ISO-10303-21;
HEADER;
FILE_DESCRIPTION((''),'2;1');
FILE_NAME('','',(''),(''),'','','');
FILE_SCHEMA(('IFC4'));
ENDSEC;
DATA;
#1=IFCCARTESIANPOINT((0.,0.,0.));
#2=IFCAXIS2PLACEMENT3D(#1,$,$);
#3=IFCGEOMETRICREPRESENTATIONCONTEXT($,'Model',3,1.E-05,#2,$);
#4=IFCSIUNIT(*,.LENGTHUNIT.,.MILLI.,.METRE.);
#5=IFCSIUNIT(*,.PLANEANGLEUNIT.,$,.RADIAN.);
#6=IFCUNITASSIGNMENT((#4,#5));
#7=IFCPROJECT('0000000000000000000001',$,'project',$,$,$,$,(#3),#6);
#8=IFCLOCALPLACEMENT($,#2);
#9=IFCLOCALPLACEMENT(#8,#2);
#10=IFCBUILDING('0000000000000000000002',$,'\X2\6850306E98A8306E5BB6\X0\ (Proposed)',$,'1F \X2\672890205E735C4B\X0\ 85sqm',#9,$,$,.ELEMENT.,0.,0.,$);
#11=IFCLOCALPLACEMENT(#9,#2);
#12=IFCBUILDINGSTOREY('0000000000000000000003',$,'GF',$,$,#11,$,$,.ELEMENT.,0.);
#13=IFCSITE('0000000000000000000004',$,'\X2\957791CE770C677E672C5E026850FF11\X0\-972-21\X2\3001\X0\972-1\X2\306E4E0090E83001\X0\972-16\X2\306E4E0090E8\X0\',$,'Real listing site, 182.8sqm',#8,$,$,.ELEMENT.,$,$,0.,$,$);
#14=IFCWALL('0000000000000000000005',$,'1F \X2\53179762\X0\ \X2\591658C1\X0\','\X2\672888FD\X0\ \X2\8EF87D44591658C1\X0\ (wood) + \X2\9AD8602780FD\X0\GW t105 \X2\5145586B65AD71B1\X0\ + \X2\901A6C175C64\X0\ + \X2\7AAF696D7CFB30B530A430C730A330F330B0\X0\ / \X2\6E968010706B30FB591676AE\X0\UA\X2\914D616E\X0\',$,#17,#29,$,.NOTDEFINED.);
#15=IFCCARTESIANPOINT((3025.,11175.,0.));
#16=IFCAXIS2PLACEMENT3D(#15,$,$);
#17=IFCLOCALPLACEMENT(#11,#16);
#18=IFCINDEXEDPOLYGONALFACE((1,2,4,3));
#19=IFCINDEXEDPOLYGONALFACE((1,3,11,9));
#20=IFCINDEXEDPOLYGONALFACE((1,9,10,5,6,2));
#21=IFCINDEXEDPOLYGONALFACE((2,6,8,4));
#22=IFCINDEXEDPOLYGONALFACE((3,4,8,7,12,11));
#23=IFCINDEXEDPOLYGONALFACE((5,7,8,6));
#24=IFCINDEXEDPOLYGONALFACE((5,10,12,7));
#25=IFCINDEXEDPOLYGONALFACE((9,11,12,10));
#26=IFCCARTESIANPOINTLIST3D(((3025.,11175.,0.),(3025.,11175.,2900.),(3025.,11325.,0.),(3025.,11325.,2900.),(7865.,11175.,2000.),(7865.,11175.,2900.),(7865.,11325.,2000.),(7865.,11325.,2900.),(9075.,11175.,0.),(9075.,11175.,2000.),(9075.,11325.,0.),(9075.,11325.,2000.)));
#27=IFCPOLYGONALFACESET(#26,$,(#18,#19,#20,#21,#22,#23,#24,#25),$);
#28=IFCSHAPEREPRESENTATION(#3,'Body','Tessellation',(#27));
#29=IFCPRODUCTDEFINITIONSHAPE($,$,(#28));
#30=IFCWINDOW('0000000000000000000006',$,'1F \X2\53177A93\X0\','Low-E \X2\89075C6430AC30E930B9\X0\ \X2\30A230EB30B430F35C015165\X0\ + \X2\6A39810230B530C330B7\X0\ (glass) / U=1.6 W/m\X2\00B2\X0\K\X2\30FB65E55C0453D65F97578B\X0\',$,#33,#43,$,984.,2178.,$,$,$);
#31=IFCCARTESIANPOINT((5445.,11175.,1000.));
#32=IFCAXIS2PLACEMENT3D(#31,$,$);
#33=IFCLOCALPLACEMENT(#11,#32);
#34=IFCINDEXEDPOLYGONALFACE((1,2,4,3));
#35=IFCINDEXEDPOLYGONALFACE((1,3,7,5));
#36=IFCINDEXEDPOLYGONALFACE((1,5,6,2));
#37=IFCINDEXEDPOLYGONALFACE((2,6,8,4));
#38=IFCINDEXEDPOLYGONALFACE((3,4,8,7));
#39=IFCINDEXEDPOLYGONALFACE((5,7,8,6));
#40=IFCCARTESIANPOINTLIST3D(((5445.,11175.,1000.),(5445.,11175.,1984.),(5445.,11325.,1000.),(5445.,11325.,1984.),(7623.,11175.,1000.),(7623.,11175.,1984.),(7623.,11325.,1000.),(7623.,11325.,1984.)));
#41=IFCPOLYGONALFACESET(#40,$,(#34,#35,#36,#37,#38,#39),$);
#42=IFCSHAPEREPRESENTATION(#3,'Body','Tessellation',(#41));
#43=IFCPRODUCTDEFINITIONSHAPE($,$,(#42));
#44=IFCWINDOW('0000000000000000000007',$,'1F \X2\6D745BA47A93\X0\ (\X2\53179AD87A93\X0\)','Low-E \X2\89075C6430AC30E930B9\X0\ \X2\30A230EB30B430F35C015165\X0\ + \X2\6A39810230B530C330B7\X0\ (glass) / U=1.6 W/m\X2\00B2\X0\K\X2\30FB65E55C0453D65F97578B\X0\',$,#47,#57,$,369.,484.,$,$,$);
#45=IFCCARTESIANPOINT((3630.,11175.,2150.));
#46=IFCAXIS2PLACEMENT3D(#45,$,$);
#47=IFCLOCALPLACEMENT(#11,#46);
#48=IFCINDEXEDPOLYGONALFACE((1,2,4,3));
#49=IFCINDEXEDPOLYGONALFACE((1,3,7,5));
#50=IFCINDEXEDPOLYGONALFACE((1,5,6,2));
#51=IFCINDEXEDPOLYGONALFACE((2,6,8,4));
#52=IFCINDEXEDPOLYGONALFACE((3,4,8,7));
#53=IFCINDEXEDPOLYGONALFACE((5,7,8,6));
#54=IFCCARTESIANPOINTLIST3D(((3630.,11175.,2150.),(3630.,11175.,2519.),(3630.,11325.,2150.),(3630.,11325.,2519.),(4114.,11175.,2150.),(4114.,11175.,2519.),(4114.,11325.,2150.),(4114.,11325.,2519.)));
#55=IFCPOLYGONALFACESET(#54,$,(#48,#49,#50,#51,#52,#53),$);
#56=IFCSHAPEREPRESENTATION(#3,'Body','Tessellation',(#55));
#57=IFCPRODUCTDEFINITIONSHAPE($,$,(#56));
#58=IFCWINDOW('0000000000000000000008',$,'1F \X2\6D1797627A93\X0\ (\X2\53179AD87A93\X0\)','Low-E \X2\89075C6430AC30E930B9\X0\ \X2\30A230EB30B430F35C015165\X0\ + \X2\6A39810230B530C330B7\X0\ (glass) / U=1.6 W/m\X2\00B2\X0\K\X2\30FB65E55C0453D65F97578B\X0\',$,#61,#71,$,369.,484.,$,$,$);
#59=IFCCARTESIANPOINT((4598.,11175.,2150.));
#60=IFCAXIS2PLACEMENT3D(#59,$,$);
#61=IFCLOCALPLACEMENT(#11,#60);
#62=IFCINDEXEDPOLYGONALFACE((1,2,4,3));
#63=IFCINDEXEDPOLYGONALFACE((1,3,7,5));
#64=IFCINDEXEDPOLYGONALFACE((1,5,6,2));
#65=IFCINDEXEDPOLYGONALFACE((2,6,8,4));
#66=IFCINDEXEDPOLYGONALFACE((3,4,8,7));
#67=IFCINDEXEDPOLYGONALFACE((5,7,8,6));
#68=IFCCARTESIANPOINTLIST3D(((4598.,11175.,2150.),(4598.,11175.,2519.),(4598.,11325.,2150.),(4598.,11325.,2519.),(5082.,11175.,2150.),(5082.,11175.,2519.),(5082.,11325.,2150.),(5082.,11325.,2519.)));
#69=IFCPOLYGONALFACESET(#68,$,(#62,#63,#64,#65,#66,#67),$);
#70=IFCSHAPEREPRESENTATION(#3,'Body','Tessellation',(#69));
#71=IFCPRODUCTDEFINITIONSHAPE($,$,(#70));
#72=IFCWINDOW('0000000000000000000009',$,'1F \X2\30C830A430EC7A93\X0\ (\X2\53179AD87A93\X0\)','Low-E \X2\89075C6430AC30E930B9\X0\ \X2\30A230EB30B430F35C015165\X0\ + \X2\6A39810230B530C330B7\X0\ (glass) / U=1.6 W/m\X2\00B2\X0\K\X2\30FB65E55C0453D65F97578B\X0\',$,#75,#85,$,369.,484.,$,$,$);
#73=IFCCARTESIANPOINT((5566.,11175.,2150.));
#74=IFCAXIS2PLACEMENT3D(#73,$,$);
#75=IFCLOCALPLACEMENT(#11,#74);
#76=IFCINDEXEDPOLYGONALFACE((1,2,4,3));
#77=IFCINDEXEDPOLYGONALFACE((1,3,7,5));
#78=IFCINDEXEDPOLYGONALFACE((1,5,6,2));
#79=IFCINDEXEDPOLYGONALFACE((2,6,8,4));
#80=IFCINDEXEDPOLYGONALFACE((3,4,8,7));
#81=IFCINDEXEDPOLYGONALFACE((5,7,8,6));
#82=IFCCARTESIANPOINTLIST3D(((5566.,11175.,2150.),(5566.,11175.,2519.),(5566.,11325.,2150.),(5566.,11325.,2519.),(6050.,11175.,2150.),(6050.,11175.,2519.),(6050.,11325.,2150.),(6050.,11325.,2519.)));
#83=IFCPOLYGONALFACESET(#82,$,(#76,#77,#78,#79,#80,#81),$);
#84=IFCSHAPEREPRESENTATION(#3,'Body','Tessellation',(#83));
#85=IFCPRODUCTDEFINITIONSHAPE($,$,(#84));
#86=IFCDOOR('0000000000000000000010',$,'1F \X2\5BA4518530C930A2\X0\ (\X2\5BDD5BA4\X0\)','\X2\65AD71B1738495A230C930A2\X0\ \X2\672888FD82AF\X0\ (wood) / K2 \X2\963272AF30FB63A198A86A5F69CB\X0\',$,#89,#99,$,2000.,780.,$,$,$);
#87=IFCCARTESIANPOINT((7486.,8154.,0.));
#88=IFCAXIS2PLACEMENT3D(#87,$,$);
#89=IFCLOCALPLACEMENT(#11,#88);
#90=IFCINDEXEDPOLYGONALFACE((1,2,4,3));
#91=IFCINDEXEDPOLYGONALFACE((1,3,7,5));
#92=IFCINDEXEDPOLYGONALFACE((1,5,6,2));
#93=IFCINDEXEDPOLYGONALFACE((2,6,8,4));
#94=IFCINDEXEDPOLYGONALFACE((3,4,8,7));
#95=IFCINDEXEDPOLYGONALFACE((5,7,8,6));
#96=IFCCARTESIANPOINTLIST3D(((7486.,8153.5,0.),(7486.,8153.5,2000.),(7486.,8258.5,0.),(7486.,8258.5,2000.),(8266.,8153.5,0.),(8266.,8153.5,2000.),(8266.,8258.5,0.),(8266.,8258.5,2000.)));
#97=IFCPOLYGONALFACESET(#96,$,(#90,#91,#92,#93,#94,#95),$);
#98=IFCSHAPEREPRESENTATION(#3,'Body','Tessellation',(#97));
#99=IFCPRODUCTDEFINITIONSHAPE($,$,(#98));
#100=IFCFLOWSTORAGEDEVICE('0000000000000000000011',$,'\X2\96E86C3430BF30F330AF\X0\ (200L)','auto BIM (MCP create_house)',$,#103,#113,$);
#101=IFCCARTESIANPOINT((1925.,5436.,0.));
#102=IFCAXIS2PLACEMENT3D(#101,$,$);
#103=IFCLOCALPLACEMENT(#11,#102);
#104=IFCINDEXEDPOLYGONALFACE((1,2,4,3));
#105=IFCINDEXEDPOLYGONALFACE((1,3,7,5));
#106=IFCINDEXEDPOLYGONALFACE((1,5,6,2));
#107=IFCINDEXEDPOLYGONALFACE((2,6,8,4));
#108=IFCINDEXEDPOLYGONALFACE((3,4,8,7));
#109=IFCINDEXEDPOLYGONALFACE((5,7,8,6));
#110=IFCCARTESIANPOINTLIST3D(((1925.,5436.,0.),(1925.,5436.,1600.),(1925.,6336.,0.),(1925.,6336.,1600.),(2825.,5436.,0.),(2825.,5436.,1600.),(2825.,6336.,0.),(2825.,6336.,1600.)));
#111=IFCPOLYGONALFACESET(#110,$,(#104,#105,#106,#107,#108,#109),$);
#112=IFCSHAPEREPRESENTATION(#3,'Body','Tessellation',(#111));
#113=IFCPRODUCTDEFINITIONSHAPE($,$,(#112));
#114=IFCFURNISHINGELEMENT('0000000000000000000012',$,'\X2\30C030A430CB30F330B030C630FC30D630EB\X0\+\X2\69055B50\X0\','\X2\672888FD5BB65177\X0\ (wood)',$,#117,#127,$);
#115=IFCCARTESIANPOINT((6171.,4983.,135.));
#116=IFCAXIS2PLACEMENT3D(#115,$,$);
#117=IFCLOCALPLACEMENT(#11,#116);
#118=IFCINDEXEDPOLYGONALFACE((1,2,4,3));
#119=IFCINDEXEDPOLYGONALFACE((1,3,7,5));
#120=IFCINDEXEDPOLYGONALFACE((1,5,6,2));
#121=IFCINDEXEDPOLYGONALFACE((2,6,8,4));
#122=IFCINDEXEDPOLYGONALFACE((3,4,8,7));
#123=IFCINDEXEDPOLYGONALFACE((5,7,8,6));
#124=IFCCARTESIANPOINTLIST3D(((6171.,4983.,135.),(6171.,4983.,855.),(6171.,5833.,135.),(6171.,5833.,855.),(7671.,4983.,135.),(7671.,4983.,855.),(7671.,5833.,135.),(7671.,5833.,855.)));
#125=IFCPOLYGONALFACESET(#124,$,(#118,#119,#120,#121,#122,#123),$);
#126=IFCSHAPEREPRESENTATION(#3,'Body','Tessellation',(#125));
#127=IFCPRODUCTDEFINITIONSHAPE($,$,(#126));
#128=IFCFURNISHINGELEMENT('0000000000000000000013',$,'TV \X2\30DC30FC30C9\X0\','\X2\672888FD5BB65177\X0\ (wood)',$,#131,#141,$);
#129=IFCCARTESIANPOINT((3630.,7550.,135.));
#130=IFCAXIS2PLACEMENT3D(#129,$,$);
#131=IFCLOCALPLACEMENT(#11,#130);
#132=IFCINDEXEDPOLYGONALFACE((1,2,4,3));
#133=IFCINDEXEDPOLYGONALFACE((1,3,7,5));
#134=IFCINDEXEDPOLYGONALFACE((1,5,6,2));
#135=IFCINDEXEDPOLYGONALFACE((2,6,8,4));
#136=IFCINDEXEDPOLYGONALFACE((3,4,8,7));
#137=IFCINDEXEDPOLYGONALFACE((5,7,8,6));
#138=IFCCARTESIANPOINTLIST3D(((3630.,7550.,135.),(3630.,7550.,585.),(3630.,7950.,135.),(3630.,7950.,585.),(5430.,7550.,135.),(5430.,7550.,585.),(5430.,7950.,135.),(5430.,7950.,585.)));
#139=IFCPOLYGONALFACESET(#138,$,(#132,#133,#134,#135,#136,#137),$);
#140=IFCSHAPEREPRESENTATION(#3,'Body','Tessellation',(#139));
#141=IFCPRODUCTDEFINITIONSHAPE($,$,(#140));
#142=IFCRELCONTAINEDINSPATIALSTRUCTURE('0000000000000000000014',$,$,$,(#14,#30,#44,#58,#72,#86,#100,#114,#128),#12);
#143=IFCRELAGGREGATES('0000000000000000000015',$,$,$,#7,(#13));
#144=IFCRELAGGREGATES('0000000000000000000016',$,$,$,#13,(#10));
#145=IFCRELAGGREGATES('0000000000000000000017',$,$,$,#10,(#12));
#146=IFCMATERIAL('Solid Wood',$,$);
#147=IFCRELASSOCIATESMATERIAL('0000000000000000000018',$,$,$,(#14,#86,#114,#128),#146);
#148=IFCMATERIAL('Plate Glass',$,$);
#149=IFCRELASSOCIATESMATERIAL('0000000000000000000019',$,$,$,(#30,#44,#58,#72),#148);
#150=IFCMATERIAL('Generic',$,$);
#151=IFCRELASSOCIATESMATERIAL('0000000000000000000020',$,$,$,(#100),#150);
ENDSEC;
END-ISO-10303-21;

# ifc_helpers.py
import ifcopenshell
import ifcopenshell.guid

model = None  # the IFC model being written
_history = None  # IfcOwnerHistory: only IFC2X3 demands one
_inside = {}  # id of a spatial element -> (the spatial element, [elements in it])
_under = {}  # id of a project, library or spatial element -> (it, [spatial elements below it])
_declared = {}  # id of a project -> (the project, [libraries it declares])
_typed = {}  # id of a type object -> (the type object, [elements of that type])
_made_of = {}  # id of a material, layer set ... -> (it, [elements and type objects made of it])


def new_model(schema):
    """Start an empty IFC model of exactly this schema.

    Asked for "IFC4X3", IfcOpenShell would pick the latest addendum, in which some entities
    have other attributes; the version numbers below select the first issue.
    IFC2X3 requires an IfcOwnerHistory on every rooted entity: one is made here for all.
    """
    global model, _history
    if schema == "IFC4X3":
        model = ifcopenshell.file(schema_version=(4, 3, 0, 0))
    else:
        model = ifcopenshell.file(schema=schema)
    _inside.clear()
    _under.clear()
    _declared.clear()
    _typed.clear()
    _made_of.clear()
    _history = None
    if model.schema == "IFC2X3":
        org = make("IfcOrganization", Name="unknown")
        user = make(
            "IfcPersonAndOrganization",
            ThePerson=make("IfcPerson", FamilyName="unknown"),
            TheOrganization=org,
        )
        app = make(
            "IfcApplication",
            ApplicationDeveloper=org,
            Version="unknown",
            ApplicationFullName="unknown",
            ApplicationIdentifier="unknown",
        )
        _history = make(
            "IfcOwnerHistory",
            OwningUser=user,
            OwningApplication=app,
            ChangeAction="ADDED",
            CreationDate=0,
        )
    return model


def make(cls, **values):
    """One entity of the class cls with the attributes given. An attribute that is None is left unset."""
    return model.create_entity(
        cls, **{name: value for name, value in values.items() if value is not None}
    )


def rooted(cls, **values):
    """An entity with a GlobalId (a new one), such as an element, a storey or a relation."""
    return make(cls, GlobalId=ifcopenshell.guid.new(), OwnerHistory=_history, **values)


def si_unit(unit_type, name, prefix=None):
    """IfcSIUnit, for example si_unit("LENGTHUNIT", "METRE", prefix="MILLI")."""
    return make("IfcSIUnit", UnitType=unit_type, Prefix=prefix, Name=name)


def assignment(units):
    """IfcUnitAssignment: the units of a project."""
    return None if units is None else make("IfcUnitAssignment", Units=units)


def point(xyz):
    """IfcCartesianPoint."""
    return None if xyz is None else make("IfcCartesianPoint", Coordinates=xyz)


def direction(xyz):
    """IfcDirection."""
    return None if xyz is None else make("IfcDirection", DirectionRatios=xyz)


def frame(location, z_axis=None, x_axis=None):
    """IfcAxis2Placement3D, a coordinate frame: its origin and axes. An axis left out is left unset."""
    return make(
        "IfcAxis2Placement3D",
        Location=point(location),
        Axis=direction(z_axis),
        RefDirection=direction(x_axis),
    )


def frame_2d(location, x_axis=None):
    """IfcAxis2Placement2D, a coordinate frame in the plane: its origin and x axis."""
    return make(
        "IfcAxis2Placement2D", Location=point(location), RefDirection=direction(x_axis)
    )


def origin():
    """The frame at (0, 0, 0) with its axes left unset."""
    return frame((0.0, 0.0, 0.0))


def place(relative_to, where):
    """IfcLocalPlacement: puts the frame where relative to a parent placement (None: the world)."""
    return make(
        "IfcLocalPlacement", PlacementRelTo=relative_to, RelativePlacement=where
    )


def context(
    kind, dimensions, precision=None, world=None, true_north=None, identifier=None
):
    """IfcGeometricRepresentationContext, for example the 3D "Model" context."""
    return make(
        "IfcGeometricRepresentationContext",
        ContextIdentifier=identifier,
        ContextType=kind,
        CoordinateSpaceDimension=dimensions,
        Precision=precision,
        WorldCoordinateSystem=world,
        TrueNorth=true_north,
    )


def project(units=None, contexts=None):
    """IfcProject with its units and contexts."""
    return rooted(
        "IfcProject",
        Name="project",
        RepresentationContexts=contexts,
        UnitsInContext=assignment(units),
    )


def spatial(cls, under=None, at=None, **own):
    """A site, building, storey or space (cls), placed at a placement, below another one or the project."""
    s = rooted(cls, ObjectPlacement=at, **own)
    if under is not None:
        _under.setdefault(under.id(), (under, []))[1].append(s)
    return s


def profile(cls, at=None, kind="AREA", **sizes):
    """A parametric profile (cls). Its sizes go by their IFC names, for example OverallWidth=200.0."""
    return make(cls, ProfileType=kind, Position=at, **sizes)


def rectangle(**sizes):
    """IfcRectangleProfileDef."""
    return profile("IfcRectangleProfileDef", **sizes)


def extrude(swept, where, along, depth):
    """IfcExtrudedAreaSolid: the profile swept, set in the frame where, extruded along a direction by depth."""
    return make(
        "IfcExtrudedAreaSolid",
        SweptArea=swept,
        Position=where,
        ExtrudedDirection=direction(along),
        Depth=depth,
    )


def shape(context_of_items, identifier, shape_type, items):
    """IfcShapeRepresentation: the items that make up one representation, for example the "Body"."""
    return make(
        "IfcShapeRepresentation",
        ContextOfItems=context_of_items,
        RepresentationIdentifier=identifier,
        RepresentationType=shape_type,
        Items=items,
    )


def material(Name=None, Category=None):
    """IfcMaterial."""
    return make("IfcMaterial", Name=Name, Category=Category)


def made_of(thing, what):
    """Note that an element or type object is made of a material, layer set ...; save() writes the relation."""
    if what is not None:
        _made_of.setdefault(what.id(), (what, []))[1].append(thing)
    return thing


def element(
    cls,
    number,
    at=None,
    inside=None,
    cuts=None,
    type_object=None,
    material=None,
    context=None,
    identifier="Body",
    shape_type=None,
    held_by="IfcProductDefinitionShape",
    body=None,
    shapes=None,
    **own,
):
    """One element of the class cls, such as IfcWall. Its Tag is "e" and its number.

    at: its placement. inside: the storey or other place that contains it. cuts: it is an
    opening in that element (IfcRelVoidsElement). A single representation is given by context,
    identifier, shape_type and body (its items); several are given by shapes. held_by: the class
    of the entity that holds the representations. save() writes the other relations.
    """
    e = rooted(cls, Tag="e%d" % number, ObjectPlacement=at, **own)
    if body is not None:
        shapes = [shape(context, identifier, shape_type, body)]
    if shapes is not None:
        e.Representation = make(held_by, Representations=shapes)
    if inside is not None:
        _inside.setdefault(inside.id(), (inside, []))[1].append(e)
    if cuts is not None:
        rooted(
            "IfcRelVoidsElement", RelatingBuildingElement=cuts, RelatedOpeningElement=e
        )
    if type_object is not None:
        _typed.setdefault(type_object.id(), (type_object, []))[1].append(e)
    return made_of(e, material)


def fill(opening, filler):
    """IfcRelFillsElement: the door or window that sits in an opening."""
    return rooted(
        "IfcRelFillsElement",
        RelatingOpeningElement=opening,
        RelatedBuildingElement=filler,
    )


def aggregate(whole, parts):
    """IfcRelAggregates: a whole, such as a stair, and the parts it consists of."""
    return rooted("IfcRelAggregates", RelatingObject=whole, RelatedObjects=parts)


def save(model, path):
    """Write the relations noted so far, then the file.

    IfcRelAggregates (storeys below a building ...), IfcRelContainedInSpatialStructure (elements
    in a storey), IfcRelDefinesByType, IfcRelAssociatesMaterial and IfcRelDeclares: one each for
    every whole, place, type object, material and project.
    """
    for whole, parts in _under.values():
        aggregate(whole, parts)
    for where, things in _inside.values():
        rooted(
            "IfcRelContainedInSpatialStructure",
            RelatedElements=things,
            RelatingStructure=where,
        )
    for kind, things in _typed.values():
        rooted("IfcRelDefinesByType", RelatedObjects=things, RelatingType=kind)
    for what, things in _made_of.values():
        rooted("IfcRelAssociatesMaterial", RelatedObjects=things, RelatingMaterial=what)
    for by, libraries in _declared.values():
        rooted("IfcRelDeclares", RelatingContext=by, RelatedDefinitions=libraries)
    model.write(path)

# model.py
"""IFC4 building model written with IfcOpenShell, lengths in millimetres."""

from ifc_helpers import new_model, si_unit, frame, frame_2d, origin, place, context, project, spatial, rectangle, extrude, material, element, fill, save


model = new_model("IFC4")

# Units and contexts
model_context = context("Model", 3, precision=1e-05, world=origin())
ifc_project = project(units=[si_unit("LENGTHUNIT", "METRE", prefix="MILLI"), si_unit("PLANEANGLEUNIT", "RADIAN")], contexts=[model_context])

# Site, building, storey
site_placement = place(None, origin())
site = spatial("IfcSite", under=ifc_project, at=site_placement, Name="長野県松本市桐１-972-21、972-1の一部、972-16の一部", ObjectType="Real listing site, 182.8sqm", CompositionType="ELEMENT", RefElevation=0.0)
building_placement = place(site_placement, origin())
building = spatial("IfcBuilding", under=site, at=building_placement, Name="桐の風の家 (Proposed)", ObjectType="1F 木造平屋 85sqm", CompositionType="ELEMENT", ElevationOfRefHeight=0.0, ElevationOfTerrain=0.0)
storey_placement = place(building_placement, origin())
storey = spatial("IfcBuildingStorey", under=building, at=storey_placement, Name="GF", CompositionType="ELEMENT", Elevation=0.0)

# Wall, openings, windows
ifc_material_1 = material(Name="Solid Wood")
wall_1_placement = place(storey_placement, frame((3025.0, 11175.0, 0.0)))
wall_1 = element("IfcWall", 1, at=wall_1_placement, inside=storey, material=ifc_material_1, Name="1F 北面 外壁", Description="木製 軸組外壁 (wood) + 高性能GW t105 充填断熱 + 通気層 + 窯業系サイディング / 準耐火・外皮UA配慮", PredefinedType="NOTDEFINED", context=model_context, shape_type="SweptSolid", body=[
    extrude(rectangle(XDim=6050.0, YDim=150.0, at=frame_2d((3025.0, 75.0))), frame((3025.0, 11175.0, 0.0)), (0.0, 0.0, 1.0), 2900.0),
])
opening_1_placement = place(storey_placement, frame((5445.0, 11175.0, 1000.0)))
opening_1 = element("IfcOpeningElement", 2, at=opening_1_placement, cuts=wall_1, PredefinedType="NOTDEFINED", context=model_context, shape_type="SweptSolid", body=[
    extrude(rectangle(XDim=2178.0, YDim=150.0, at=frame_2d((1089.0, 75.0))), frame((5445.0, 11175.0, 1000.0)), (0.0, 0.0, 1.0), 984.0),
])
opening_2_placement = place(storey_placement, frame((3630.0, 11175.0, 2150.0)))
opening_2 = element("IfcOpeningElement", 3, at=opening_2_placement, cuts=wall_1, PredefinedType="NOTDEFINED", context=model_context, shape_type="SweptSolid", body=[
    extrude(rectangle(XDim=484.0, YDim=150.0, at=frame_2d((242.0, 75.0))), frame((3630.0, 11175.0, 2150.0)), (0.0, 0.0, 1.0), 369.0),
])
opening_3_placement = place(storey_placement, frame((4598.0, 11175.0, 2150.0)))
opening_3 = element("IfcOpeningElement", 4, at=opening_3_placement, cuts=wall_1, PredefinedType="NOTDEFINED", context=model_context, shape_type="SweptSolid", body=[
    extrude(rectangle(XDim=484.0, YDim=150.0, at=frame_2d((242.0, 75.0))), frame((4598.0, 11175.0, 2150.0)), (0.0, 0.0, 1.0), 369.0),
])
opening_4_placement = place(storey_placement, frame((5566.0, 11175.0, 2150.0)))
opening_4 = element("IfcOpeningElement", 5, at=opening_4_placement, cuts=wall_1, PredefinedType="NOTDEFINED", context=model_context, shape_type="SweptSolid", body=[
    extrude(rectangle(XDim=484.0, YDim=150.0, at=frame_2d((242.0, 75.0))), frame((5566.0, 11175.0, 2150.0)), (0.0, 0.0, 1.0), 369.0),
])
ifc_material_2 = material(Name="Plate Glass")
window_1_placement = place(storey_placement, frame((5445.0, 11175.0, 1000.0)))
window_1 = element("IfcWindow", 6, at=window_1_placement, inside=storey, material=ifc_material_2, Name="1F 北窓", Description="Low-E 複層ガラス アルゴン封入 + 樹脂サッシ (glass) / U=1.6 W/m²K・日射取得型", OverallHeight=984.0, OverallWidth=2178.0, context=model_context, shape_type="SweptSolid", body=[
    extrude(rectangle(XDim=2178.0, YDim=150.0, at=frame_2d((1089.0, 75.0))), frame((5445.0, 11175.0, 1000.0)), (0.0, 0.0, 1.0), 984.0),
])
fill(opening_1, window_1)
window_2_placement = place(storey_placement, frame((3630.0, 11175.0, 2150.0)))
window_2 = element("IfcWindow", 7, at=window_2_placement, inside=storey, material=ifc_material_2, Name="1F 浴室窓 (北高窓)", Description="Low-E 複層ガラス アルゴン封入 + 樹脂サッシ (glass) / U=1.6 W/m²K・日射取得型", OverallHeight=369.0, OverallWidth=484.0, context=model_context, shape_type="SweptSolid", body=[
    extrude(rectangle(XDim=484.0, YDim=150.0, at=frame_2d((242.0, 75.0))), frame((3630.0, 11175.0, 2150.0)), (0.0, 0.0, 1.0), 369.0),
])
fill(opening_2, window_2)
window_3_placement = place(storey_placement, frame((4598.0, 11175.0, 2150.0)))
window_3 = element("IfcWindow", 8, at=window_3_placement, inside=storey, material=ifc_material_2, Name="1F 洗面窓 (北高窓)", Description="Low-E 複層ガラス アルゴン封入 + 樹脂サッシ (glass) / U=1.6 W/m²K・日射取得型", OverallHeight=369.0, OverallWidth=484.0, context=model_context, shape_type="SweptSolid", body=[
    extrude(rectangle(XDim=484.0, YDim=150.0, at=frame_2d((242.0, 75.0))), frame((4598.0, 11175.0, 2150.0)), (0.0, 0.0, 1.0), 369.0),
])
fill(opening_3, window_3)
window_4_placement = place(storey_placement, frame((5566.0, 11175.0, 2150.0)))
window_4 = element("IfcWindow", 9, at=window_4_placement, inside=storey, material=ifc_material_2, Name="1F トイレ窓 (北高窓)", Description="Low-E 複層ガラス アルゴン封入 + 樹脂サッシ (glass) / U=1.6 W/m²K・日射取得型", OverallHeight=369.0, OverallWidth=484.0, context=model_context, shape_type="SweptSolid", body=[
    extrude(rectangle(XDim=484.0, YDim=150.0, at=frame_2d((242.0, 75.0))), frame((5566.0, 11175.0, 2150.0)), (0.0, 0.0, 1.0), 369.0),
])
fill(opening_4, window_4)

# Door
door_1_placement = place(storey_placement, frame((7486.0, 8154.0, 0.0)))
element("IfcDoor", 10, at=door_1_placement, inside=storey, material=ifc_material_1, Name="1F 室内ドア (寝室)", Description="断熱玄関ドア 木製芯 (wood) / K2 防犯・採風機構", OverallHeight=2000.0, OverallWidth=780.0, context=model_context, shape_type="SweptSolid", body=[
    extrude(rectangle(XDim=780.0, YDim=105.0, at=frame_2d((390.0, 52.0))), frame((7486.0, 8154.0, 0.0)), (0.0, 0.0, 1.0), 2000.0),
])

# Flow storage device
ifc_material_3 = material(Name="Generic")
flow_storage_device_placement = place(storey_placement, frame((1925.0, 5436.0, 0.0)))
element("IfcFlowStorageDevice", 11, at=flow_storage_device_placement, inside=storey, material=ifc_material_3, Name="雨水タンク (200L)", Description="auto BIM (MCP create_house)", context=model_context, shape_type="SweptSolid", body=[
    extrude(rectangle(XDim=900.0, YDim=900.0, at=frame_2d((450.0, 450.0))), frame((1925.0, 5436.0, 0.0)), (0.0, 0.0, 1.0), 1600.0),
])

# Furnishing elements
furnishing_1_placement = place(storey_placement, frame((6171.0, 4983.0, 135.0)))
element("IfcFurnishingElement", 12, at=furnishing_1_placement, inside=storey, material=ifc_material_1, Name="ダイニングテーブル+椅子", Description="木製家具 (wood)", context=model_context, shape_type="SweptSolid", body=[
    extrude(rectangle(XDim=1500.0, YDim=850.0, at=frame_2d((750.0, 425.0))), frame((6171.0, 4983.0, 135.0)), (0.0, 0.0, 1.0), 720.0),
])
furnishing_2_placement = place(storey_placement, frame((3630.0, 7550.0, 135.0)))
element("IfcFurnishingElement", 13, at=furnishing_2_placement, inside=storey, material=ifc_material_1, Name="TV ボード", Description="木製家具 (wood)", context=model_context, shape_type="SweptSolid", body=[
    extrude(rectangle(XDim=1800.0, YDim=400.0, at=frame_2d((900.0, 200.0))), frame((3630.0, 7550.0, 135.0)), (0.0, 0.0, 1.0), 450.0),
])

save(model, "model.ifc")
